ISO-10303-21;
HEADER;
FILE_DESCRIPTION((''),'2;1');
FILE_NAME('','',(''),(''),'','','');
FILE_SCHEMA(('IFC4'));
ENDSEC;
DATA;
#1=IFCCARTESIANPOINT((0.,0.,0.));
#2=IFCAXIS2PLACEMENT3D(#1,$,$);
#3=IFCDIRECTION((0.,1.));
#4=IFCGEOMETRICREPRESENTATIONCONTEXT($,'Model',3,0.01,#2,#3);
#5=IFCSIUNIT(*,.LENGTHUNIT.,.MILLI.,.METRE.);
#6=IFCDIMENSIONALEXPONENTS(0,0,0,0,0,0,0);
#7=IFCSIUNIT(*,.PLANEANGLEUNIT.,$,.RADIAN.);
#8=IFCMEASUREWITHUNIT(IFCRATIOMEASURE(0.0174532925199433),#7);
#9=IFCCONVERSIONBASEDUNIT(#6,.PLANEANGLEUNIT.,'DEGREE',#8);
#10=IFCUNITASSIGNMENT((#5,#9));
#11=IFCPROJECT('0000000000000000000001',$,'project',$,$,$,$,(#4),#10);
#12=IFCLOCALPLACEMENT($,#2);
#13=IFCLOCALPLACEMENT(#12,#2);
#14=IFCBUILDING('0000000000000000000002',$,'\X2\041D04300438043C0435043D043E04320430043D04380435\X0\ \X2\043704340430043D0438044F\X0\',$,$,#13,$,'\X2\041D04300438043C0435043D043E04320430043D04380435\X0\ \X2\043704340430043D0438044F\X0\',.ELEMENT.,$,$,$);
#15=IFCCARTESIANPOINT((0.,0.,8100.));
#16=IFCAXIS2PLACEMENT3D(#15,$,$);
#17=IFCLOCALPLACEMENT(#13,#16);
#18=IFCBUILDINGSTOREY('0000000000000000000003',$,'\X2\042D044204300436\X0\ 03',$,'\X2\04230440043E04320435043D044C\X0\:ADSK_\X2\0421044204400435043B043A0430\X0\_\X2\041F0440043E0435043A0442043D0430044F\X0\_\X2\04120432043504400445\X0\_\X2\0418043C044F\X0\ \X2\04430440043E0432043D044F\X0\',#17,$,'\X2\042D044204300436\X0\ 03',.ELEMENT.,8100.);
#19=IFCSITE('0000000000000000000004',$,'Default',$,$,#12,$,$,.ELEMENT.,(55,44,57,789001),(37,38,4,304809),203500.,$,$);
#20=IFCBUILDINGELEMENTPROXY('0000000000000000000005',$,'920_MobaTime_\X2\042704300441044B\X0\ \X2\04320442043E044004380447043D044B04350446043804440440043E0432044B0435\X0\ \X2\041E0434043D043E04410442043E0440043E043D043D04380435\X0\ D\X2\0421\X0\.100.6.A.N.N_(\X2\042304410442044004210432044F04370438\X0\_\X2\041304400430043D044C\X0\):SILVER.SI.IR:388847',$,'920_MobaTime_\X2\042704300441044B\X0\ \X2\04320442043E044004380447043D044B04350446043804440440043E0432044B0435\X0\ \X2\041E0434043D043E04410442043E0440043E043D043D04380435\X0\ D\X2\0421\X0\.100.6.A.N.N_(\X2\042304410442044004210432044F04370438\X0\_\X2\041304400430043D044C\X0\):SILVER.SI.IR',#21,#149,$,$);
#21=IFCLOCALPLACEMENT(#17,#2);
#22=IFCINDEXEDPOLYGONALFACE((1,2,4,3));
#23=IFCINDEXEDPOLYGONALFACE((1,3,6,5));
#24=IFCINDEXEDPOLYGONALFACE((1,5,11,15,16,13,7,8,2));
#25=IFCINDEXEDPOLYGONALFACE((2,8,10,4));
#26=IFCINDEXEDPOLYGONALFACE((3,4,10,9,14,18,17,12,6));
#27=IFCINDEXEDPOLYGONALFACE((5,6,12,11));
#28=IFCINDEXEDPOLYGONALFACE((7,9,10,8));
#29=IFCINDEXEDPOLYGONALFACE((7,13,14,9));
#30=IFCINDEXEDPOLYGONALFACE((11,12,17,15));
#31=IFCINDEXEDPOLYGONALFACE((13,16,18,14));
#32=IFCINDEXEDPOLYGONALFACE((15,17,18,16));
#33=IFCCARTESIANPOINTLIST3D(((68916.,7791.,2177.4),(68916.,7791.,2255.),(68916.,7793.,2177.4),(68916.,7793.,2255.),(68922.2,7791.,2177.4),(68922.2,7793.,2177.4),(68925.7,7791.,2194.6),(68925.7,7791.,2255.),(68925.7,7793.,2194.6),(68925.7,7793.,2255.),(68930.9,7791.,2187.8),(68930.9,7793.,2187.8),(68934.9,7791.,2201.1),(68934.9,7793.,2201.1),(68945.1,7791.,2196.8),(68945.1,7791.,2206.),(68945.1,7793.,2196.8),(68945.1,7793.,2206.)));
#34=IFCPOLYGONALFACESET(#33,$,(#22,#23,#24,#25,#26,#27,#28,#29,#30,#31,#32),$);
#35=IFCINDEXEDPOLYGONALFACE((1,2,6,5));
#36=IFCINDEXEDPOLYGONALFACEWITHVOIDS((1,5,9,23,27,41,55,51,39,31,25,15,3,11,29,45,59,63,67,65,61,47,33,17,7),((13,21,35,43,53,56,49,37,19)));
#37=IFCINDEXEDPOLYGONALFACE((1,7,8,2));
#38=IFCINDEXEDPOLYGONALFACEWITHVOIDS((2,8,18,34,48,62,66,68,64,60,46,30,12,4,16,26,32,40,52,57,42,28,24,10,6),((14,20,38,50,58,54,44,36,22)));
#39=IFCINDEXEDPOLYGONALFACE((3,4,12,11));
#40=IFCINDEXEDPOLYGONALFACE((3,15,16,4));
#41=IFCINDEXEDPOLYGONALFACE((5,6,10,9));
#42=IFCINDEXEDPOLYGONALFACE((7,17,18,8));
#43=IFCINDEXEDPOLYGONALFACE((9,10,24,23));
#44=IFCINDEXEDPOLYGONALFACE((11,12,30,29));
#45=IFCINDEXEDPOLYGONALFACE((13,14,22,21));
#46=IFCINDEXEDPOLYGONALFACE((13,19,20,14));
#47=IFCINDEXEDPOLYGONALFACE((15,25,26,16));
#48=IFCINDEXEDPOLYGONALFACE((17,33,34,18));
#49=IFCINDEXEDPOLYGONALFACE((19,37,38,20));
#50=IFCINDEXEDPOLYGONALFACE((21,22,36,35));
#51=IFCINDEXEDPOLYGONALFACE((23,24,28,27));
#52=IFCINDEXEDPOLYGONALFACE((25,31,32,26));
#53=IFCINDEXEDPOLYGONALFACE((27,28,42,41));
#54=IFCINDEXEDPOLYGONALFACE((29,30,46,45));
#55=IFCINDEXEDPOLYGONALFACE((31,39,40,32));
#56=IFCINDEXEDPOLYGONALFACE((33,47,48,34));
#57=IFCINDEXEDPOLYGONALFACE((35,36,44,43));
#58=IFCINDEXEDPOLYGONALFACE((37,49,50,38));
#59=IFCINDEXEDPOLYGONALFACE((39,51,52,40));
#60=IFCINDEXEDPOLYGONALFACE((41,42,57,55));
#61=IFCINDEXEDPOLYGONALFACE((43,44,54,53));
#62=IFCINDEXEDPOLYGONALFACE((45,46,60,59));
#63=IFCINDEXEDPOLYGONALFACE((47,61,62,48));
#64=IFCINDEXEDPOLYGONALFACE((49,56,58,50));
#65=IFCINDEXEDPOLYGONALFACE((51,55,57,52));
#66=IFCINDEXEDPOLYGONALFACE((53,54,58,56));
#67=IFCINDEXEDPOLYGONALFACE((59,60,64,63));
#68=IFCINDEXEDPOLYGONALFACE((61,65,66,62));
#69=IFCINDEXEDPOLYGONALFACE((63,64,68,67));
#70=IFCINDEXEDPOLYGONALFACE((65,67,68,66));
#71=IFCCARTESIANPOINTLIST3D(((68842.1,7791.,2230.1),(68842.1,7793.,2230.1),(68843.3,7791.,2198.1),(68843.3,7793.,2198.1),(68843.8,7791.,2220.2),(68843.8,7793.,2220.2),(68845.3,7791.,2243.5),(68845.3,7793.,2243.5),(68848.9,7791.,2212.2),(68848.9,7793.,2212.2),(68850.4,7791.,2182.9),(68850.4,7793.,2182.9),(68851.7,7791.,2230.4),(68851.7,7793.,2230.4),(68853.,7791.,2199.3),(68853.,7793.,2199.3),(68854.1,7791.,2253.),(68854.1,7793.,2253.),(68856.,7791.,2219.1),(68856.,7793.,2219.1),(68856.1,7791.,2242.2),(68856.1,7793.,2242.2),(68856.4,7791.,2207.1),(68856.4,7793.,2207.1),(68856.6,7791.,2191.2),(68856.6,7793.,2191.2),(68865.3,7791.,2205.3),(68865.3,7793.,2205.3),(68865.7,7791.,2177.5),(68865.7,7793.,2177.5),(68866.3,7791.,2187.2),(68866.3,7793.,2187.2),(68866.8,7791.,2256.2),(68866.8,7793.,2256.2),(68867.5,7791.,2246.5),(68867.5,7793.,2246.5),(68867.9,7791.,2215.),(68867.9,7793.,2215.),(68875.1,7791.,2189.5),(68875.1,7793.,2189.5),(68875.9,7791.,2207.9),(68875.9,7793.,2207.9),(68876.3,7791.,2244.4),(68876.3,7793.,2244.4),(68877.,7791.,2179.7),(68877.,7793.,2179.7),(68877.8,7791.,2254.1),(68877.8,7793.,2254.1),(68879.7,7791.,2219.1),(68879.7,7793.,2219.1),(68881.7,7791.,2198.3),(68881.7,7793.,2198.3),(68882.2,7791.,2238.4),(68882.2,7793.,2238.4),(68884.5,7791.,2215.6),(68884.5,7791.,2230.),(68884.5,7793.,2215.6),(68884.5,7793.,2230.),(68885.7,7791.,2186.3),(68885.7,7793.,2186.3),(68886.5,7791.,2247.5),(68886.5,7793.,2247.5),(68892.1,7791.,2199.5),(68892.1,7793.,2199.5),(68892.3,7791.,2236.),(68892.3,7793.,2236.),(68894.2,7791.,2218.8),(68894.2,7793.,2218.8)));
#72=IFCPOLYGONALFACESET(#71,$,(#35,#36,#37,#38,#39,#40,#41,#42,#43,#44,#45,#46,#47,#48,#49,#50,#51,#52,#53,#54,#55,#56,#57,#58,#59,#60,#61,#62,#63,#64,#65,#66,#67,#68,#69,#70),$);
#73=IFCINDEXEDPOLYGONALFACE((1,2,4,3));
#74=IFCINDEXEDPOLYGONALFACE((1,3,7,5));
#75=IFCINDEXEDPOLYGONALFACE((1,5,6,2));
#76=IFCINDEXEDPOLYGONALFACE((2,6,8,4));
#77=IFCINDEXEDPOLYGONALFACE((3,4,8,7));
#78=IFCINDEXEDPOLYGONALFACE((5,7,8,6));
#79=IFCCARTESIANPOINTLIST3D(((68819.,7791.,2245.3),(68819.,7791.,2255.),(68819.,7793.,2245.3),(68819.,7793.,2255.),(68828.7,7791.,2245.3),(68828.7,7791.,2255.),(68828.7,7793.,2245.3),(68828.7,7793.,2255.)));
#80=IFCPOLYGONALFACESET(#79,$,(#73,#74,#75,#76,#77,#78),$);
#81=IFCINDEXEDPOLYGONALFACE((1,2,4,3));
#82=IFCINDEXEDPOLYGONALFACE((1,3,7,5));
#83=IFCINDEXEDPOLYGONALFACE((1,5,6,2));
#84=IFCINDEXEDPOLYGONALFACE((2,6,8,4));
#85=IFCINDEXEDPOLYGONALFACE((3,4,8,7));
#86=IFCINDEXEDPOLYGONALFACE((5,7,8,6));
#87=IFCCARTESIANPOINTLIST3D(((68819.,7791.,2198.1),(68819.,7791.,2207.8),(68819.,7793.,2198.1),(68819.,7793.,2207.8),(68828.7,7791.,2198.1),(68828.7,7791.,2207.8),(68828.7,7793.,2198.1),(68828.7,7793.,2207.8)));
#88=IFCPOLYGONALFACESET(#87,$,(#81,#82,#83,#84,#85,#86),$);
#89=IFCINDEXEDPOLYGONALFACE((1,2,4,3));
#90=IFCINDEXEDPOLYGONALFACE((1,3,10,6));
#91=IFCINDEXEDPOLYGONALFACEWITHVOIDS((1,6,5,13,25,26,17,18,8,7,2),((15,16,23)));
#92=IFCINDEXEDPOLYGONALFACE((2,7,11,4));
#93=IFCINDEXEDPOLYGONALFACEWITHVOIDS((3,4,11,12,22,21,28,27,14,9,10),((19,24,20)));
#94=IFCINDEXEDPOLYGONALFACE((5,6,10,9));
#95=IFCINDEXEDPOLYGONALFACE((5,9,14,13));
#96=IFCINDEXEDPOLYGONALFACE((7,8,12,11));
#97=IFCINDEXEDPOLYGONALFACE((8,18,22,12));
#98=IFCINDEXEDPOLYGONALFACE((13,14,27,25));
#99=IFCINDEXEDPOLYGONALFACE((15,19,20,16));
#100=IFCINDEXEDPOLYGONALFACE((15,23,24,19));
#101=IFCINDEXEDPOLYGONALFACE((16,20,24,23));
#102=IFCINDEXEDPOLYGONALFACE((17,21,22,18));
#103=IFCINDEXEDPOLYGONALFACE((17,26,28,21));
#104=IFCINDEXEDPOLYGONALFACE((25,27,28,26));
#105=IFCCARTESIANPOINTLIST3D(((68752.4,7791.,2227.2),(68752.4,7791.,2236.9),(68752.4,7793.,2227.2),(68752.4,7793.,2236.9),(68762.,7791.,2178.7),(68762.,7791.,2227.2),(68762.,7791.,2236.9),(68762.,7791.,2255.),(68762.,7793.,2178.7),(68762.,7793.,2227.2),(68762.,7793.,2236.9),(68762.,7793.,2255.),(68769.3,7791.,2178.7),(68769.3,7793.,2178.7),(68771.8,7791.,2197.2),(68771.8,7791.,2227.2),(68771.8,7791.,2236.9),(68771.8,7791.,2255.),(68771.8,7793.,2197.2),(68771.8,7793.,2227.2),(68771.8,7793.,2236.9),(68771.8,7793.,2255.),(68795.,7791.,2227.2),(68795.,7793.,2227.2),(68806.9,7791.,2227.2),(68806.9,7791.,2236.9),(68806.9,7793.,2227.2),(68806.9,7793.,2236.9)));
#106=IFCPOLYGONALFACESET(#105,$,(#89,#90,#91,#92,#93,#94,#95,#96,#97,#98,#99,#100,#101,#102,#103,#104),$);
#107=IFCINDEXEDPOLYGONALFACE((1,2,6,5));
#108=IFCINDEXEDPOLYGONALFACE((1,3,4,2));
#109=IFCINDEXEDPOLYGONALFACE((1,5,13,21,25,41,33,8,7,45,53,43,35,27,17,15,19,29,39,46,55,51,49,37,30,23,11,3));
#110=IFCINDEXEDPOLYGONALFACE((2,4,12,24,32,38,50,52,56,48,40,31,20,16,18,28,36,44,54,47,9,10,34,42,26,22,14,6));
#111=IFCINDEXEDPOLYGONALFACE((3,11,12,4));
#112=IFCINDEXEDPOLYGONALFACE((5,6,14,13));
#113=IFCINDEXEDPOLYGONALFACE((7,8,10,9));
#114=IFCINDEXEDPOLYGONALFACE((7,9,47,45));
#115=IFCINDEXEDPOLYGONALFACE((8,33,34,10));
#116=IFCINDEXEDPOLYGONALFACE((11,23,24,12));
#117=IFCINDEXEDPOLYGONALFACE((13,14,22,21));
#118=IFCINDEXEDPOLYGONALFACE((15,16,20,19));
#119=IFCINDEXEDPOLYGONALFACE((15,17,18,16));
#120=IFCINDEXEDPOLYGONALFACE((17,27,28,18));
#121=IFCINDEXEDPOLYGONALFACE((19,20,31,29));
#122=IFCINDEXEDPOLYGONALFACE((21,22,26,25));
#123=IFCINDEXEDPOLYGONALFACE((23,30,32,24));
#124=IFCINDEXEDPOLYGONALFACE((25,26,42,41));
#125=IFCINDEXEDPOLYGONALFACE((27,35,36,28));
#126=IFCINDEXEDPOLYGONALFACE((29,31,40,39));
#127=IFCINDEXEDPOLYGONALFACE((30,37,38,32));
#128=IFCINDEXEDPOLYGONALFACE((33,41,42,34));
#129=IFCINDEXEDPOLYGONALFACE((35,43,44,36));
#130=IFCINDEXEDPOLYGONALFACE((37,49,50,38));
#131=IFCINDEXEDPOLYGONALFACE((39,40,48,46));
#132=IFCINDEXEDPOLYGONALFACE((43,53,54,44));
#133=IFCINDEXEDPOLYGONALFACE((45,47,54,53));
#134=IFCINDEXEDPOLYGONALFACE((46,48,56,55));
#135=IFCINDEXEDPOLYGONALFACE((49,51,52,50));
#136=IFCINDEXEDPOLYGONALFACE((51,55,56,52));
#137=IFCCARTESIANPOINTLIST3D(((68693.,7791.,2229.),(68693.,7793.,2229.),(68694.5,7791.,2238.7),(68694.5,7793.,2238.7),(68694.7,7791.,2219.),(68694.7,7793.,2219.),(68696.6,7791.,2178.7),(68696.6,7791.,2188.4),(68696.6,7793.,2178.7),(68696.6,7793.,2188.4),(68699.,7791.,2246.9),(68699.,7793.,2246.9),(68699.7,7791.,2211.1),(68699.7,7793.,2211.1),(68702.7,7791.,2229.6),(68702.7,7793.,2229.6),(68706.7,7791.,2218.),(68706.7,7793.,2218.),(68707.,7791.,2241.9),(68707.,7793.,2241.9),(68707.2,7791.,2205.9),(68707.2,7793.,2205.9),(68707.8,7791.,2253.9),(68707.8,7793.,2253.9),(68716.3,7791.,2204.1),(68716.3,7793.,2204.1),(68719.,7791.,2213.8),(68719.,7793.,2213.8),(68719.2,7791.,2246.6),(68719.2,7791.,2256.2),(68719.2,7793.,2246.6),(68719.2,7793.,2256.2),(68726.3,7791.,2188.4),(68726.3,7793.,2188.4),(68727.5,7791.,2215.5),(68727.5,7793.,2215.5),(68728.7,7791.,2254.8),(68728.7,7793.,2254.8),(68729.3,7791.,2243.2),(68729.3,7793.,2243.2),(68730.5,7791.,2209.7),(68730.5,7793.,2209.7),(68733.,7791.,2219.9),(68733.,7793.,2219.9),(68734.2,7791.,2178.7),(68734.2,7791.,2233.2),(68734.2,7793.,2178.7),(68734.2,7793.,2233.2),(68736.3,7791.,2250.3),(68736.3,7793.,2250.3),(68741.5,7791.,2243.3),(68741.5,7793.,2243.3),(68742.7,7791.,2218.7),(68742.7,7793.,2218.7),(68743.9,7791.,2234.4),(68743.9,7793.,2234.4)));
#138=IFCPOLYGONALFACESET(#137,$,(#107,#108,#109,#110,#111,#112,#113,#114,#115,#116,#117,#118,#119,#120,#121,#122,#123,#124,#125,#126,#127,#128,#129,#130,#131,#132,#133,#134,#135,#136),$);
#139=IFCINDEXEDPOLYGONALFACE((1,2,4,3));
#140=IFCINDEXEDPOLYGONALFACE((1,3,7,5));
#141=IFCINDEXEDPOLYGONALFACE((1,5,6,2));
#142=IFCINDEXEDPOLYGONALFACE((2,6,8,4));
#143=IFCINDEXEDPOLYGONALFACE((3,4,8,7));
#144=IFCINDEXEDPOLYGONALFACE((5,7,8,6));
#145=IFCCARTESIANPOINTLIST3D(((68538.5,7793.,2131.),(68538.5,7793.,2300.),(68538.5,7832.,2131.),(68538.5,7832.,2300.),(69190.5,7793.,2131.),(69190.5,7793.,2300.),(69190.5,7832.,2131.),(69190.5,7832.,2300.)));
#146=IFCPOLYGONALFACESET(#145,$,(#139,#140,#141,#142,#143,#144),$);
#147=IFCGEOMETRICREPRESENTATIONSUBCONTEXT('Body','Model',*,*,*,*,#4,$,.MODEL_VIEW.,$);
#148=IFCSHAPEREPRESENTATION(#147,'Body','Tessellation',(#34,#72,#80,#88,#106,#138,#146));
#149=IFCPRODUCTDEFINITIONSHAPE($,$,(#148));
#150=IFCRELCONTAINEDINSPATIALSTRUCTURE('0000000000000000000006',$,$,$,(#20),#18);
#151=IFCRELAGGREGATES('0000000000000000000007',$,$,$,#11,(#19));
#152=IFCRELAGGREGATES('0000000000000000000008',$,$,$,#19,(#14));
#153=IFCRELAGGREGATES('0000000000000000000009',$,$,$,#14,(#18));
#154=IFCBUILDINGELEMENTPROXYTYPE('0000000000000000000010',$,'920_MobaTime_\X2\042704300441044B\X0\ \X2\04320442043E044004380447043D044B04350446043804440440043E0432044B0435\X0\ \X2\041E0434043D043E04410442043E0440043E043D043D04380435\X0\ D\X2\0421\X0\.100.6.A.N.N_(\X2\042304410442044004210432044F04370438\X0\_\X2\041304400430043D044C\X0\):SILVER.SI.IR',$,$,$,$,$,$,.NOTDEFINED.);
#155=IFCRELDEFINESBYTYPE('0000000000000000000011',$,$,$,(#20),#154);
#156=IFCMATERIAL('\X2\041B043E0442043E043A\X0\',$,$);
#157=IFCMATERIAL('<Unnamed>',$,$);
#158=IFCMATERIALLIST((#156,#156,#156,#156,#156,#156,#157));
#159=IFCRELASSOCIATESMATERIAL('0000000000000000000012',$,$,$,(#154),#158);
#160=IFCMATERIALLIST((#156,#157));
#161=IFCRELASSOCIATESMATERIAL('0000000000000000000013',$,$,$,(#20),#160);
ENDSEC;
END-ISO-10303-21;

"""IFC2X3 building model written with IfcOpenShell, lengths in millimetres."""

from ifc_helpers import new_model, entity, si_unit, converted_unit, direction, frame, origin, origin_2d_with_axis, place, context, subcontext, project, spatial, polyline, rectangle, outline, extrude, source, transform, mapped, material, material_list, type_object, type_shapes, element, save


model = new_model("IFC2X3")

# Units and contexts
model_context = context("Model", 3, precision=0.01, world=origin(), true_north=direction((0.0, 1.0)))
body_context = subcontext(model_context, "Body", "Model", "MODEL_VIEW")
ifc_project = project(units=[si_unit("LENGTHUNIT", "METRE", prefix="MILLI"), converted_unit("PLANEANGLEUNIT", "DEGREE", entity("IfcRatioMeasure", 0.0174532925199433), si_unit("PLANEANGLEUNIT", "RADIAN"), dimensions=[0, 0, 0, 0, 0, 0, 0])], contexts=[model_context])

# Site, building, storey
site_placement = place(None, origin())
site = spatial("IfcSite", under=ifc_project, at=site_placement, Name="Default", CompositionType="ELEMENT", RefLatitude=(55, 44, 57, 789001), RefLongitude=(37, 38, 4, 304809), RefElevation=203500.0)
building_placement = place(site_placement, origin())
building = spatial("IfcBuilding", under=site, at=building_placement, Name="Наименование здания", LongName="Наименование здания", CompositionType="ELEMENT")
storey_placement = place(building_placement, frame((0.0, 0.0, 8100.0)))
storey = spatial("IfcBuildingStorey", under=building, at=storey_placement, Name="Этаж 03", ObjectType="Уровень:ADSK_Стрелка_Проектная_Вверх_Имя уровня", LongName="Этаж 03", CompositionType="ELEMENT", Elevation=8100.0)

# Building element proxy
ifc_material_1 = material(Name="Лоток")
ifc_material_2 = material(Name="<Unnamed>")
ifc_material_list_1 = material_list([ifc_material_1, ifc_material_1, ifc_material_1, ifc_material_1, ifc_material_1, ifc_material_1, ifc_material_2])
building_element_proxy_type = type_object("IfcBuildingElementProxyType", Name="920_MobaTime_Часы вторичныецифровые Односторонние DС.100.6.A.N.N_(УстрСвязи_Грань):SILVER.SI.IR", PredefinedType="NOTDEFINED", material=ifc_material_list_1)
shared_shape = source(origin(), body_context, "Body", "SweptSolid", [
    extrude(outline(polyline([(-49.3, -13.1), (28.2, -13.1), (28.2, -6.8), (17.9, 1.8), (8.8, 16.0), (-0.3, 16.0), (4.6, 5.8), (11.1, -3.4), (-49.3, -3.4), (-49.3, -13.1)])), frame((-64.6, 9.8, 39.0), z_axis=(0.0, 0.0, 1.0), x_axis=(0.0, 1.0, 0.0)), (0.0, 0.0, 1.0), 2.0),
    extrude(outline(polyline([(2.2, -27.6), (19.0, -27.6), (30.5, -16.1), (33.3, -4.9), (31.0, 5.8), (21.8, 17.2), (5.2, 27.3), (-11.1, 33.0), (-24.0, 32.7), (-33.6, 27.6), (-40.3, 18.6), (-42.8, 5.7), (-38.0, -6.3), (-27.2, -14.9), (-17.5, -17.7), (-8.2, -16.4), (-0.3, -11.9), (5.1, -4.5), (7.3, 6.2), (4.0, 17.2), (18.4, 7.3), (23.6, -2.4), (22.0, -11.4), (14.2, -18.4), (5.3, -18.3), (2.2, -27.6)]), holes=[polyline([(-9.0, 23.3), (-1.3, 14.3), (-2.5, 2.0), (-11.4, -7.0), (-23.4, -6.0), (-32.2, 2.9), (-31.2, 15.1), (-25.6, 22.1), (-17.5, 24.9), (-9.0, 23.3)])]), frame((-2.7, 3.6, 39.0), z_axis=(0.0, 0.0, 1.0), x_axis=(-0.427649, 0.903945, 0.0)), (0.0, 0.0, 1.0), 2.0),
    extrude(rectangle(XDim=9.7, YDim=9.7, at=origin_2d_with_axis()), frame((40.6, -34.7, 39.0)), (0.0, 0.0, 1.0), 2.0),
    extrude(rectangle(XDim=9.7, YDim=9.7, at=origin_2d_with_axis()), frame((40.6, 12.6, 39.0)), (0.0, 0.0, 1.0), 2.0),
    extrude(outline(polyline([(-0.9, -28.1), (8.8, -28.1), (8.8, -9.9), (18.5, -9.9), (18.5, -0.2), (8.8, -0.2), (8.8, 48.3), (1.5, 48.3), (-36.0, -0.2), (-36.0, -9.9), (-0.9, -9.9), (-0.9, -28.1)]), holes=[polyline([(-0.9, -0.2), (-24.1, -0.2), (-0.9, 29.7), (-0.9, -0.2)])]), frame((93.6, -11.4, 39.0)), (0.0, 0.0, 1.0), 2.0),
    extrude(outline(polyline([(3.3, -28.3), (12.5, -28.3), (20.5, -25.0), (26.8, -18.9), (30.7, -10.0), (31.4, 1.6), (26.9, 11.8), (20.1, 18.4), (11.1, 22.3), (1.0, 23.3), (-7.9, 20.4), (-14.9, 14.5), (-18.9, 6.2), (-17.1, -9.0), (-36.7, 0.5), (-29.1, 29.2), (-38.5, 31.7), (-48.1, -4.6), (-11.6, -23.1), (-8.0, -14.0), (-10.8, -7.6), (-10.2, 1.1), (-3.0, 11.8), (9.2, 12.8), (20.0, 5.5), (21.4, -7.5), (15.5, -16.4), (4.6, -18.6), (3.3, -28.3)])), frame((147.1, -8.5, 39.0), z_axis=(0.0, 0.0, 1.0), x_axis=(0.256974, -0.966418, 0.0)), (0.0, 0.0, 1.0), 2.0),
    extrude(rectangle(XDim=652.0, YDim=169.0, at=origin_2d_with_axis()), frame((0.0, 0.0, 0.0), z_axis=(0.0, 0.0, 1.0), x_axis=(-1.0, 0.0, 0.0)), (0.0, 0.0, 1.0), 39.0),
])
type_shapes(building_element_proxy_type, [shared_shape])
ifc_material_list_2 = material_list([ifc_material_1, ifc_material_2])
for number, where, z_axis, x_axis, name in (
    (1, (68864.5, 7832.0, 2215.5), (0.0, -1.0, 0.0), (-1.0, 0.0, 0.0), "920_MobaTime_Часы вторичныецифровые Односторонние DС.100.6.A.N.N_(УстрСвязи_Грань):SILVER.SI.IR:388847"),
):
    element("IfcBuildingElementProxy", number, at=place(storey_placement, frame(where, z_axis=z_axis, x_axis=x_axis)), inside=storey, type_object=building_element_proxy_type, material=ifc_material_list_2, Name=name, ObjectType="920_MobaTime_Часы вторичныецифровые Односторонние DС.100.6.A.N.N_(УстрСвязи_Грань):SILVER.SI.IR", context=body_context, shape_type="MappedRepresentation", body=[
        mapped(shared_shape, transform((0.0, 0.0, 0.0), scale=1.0)),
    ])

save(model, "model.ifc")
